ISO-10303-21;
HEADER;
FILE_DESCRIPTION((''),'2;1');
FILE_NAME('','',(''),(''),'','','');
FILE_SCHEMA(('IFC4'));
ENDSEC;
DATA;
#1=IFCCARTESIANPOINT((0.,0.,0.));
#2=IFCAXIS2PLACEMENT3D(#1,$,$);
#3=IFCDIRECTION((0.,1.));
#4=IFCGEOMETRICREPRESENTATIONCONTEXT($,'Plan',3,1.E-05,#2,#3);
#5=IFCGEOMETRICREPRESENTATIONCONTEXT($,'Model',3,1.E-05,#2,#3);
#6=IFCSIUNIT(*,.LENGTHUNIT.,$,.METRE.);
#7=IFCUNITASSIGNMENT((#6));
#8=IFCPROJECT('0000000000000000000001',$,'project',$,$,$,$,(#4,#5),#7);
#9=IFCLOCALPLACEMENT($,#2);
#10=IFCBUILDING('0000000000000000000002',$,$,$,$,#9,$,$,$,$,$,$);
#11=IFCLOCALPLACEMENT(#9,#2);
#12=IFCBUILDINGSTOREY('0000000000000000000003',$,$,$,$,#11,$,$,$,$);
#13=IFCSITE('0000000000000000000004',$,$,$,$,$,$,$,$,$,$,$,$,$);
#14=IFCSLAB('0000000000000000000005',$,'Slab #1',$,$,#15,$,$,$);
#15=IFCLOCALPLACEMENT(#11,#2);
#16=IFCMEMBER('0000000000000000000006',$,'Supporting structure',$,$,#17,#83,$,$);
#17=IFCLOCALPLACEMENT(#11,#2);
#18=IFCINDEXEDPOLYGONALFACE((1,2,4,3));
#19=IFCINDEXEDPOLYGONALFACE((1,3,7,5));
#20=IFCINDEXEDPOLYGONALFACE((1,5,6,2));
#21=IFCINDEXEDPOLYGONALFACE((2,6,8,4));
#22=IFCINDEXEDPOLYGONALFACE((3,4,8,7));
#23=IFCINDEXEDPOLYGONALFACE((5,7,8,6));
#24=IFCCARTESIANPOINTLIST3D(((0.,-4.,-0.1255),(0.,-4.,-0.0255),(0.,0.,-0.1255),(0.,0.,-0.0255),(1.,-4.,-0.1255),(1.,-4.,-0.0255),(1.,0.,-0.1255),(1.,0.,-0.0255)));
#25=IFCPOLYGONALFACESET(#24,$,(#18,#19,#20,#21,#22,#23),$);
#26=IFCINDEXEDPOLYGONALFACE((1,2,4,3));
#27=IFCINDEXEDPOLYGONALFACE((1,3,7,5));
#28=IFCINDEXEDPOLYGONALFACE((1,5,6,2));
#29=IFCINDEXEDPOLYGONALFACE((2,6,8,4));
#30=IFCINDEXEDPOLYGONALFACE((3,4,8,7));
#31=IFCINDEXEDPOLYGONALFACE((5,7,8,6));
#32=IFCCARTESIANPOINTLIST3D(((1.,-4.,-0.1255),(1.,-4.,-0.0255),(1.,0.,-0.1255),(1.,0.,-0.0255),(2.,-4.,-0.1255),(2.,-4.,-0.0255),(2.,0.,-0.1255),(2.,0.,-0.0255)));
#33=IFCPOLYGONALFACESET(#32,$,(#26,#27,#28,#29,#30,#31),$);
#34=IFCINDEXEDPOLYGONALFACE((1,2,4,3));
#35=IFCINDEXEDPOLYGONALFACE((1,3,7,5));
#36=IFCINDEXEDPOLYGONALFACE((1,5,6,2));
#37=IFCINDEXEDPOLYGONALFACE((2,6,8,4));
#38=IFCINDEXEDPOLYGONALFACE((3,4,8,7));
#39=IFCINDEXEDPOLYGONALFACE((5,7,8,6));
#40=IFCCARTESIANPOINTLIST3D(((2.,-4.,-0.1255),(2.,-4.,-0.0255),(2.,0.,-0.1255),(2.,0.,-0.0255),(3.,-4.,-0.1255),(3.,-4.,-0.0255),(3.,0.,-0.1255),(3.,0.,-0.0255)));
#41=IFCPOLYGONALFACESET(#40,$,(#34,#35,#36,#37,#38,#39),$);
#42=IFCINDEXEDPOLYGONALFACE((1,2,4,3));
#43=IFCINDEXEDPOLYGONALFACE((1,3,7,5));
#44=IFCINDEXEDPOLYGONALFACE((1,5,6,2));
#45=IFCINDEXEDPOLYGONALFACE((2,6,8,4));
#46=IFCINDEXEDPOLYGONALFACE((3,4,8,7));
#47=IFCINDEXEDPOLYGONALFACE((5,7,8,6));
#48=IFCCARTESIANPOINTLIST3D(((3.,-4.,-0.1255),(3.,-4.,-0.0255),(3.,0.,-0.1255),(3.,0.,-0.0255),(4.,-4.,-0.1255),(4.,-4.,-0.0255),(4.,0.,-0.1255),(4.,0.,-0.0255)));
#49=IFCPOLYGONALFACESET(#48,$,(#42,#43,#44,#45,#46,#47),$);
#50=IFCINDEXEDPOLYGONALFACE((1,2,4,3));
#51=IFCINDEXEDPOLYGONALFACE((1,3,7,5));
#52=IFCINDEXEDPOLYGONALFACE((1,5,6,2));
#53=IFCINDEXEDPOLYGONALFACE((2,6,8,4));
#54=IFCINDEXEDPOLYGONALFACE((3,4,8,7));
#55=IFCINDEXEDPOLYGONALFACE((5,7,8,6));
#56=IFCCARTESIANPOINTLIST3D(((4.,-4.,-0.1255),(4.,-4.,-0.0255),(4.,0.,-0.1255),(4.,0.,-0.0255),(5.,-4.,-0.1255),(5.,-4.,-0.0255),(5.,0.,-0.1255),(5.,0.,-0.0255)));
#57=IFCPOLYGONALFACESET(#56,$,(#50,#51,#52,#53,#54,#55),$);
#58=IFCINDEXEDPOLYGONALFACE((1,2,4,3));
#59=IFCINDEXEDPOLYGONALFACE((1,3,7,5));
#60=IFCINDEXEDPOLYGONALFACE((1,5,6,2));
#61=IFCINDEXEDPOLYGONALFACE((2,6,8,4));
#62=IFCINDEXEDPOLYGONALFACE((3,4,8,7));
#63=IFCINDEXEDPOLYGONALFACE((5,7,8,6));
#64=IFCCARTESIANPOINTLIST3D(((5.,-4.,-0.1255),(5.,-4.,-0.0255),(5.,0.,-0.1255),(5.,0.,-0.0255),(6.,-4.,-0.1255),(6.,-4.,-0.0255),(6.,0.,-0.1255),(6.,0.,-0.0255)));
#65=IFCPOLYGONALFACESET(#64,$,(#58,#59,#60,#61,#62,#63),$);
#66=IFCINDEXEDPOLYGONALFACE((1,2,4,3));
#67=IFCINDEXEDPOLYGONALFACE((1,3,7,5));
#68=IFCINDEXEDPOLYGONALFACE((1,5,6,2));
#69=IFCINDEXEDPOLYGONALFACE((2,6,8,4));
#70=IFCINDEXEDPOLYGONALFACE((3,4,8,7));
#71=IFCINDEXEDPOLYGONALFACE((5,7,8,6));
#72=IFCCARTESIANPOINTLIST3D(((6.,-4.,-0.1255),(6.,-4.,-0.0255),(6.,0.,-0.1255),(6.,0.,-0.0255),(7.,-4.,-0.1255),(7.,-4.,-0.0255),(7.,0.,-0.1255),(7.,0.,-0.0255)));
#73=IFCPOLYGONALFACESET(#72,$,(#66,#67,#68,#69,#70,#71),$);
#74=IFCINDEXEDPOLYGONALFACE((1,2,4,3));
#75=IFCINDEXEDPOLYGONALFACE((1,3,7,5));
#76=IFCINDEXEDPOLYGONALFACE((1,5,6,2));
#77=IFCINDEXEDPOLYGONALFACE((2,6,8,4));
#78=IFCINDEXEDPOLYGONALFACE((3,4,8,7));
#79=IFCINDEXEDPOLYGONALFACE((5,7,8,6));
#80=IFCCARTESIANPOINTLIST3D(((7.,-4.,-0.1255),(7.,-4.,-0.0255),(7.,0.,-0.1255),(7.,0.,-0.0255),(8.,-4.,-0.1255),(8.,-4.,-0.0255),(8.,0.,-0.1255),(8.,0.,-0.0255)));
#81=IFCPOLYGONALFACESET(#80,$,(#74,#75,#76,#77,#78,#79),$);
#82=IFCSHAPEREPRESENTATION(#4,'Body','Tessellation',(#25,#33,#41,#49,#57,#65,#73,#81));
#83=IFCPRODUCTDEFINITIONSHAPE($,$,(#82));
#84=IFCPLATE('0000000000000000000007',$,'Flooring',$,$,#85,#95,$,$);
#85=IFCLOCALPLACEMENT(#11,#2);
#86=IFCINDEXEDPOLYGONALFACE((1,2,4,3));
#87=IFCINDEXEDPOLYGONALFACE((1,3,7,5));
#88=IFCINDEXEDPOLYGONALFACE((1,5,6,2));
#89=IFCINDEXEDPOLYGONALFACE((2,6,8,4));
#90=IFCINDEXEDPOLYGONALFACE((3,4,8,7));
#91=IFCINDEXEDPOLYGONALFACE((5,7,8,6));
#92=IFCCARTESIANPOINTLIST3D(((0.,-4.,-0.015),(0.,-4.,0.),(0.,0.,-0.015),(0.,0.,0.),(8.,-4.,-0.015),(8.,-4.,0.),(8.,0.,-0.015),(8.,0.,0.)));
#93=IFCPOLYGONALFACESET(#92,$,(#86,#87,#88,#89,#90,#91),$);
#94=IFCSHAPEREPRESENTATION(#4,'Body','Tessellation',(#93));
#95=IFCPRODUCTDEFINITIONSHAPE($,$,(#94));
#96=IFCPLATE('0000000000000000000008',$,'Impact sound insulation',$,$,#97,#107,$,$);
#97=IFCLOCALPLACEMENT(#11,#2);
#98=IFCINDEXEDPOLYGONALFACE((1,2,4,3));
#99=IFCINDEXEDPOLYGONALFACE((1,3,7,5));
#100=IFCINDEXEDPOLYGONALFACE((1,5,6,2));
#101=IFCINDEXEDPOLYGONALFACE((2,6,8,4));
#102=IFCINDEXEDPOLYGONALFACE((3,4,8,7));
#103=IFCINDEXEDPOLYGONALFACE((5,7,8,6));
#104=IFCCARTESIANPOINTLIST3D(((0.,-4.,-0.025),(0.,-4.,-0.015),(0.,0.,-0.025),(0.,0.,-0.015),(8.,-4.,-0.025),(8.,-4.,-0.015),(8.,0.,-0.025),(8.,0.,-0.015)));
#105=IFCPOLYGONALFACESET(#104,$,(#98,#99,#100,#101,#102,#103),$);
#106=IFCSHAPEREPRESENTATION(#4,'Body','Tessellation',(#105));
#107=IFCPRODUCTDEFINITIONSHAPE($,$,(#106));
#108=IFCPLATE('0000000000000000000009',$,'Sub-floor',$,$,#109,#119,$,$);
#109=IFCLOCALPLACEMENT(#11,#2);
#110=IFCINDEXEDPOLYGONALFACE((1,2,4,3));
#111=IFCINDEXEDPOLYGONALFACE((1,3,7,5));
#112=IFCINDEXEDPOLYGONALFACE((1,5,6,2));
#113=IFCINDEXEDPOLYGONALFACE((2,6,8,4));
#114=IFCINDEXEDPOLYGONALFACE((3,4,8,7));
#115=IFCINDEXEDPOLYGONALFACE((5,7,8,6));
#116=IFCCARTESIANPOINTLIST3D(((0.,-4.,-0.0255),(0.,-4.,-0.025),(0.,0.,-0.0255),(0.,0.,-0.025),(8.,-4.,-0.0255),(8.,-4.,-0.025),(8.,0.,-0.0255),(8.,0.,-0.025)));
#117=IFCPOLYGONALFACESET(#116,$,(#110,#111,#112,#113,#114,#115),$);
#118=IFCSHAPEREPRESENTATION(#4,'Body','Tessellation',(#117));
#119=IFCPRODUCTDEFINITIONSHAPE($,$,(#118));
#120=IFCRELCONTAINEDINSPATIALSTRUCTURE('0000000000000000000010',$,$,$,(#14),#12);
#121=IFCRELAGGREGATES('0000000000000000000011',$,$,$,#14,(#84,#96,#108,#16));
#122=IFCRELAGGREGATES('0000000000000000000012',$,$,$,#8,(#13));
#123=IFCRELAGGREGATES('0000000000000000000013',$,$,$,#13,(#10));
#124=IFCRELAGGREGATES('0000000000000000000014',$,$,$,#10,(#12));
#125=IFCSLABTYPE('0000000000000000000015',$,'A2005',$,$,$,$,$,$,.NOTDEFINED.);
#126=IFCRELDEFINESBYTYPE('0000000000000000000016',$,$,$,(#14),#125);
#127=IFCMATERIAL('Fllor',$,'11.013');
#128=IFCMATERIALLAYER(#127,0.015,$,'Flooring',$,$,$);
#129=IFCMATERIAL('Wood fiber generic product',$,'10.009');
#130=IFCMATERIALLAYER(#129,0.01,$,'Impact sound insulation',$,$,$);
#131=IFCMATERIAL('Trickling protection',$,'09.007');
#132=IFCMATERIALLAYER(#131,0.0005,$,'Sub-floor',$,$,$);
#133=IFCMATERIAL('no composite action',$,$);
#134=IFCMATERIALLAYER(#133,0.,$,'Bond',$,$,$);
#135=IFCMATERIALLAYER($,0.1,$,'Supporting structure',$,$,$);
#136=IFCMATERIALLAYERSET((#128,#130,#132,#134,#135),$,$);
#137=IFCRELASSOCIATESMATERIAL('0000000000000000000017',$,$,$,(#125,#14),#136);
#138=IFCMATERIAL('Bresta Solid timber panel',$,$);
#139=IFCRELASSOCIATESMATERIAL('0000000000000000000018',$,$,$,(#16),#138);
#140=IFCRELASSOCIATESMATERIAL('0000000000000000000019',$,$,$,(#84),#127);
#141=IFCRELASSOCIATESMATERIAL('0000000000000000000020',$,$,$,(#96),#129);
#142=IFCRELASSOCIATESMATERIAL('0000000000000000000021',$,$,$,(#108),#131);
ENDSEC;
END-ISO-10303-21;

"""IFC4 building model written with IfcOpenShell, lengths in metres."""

from ifc_helpers import new_model, si_unit, direction, frame, frame_2d, origin, origin_with_axes, place, context, project, spatial, rectangle, extrude, material, layer, layer_set, type_object, element, aggregate, save


model = new_model("IFC4")

# Units and contexts
plan_context = context("Plan", 3, precision=1e-05, world=origin(), true_north=direction((0.0, 1.0)))
model_context = context("Model", 3, precision=1e-05, world=origin(), true_north=direction((0.0, 1.0)))
ifc_project = project(units=[si_unit("LENGTHUNIT", "METRE")], contexts=[plan_context, model_context])

# Site, building, storey
site = spatial("IfcSite", under=ifc_project)
building_placement = place(None, origin())
building = spatial("IfcBuilding", under=site, at=building_placement)
storey_placement = place(building_placement, origin())
storey = spatial("IfcBuildingStorey", under=building, at=storey_placement)

# Slab, member, plates
ifc_material_1 = material(Name="Fllor", Category="11.013")
ifc_layer_1 = layer(ifc_material_1, 0.015, Name="Flooring")
ifc_material_2 = material(Name="Wood fiber generic product", Category="10.009")
ifc_layer_2 = layer(ifc_material_2, 0.01, Name="Impact sound insulation")
ifc_material_3 = material(Name="Trickling protection", Category="09.007")
ifc_layer_3 = layer(ifc_material_3, 0.0005, Name="Sub-floor")
ifc_material_4 = material(Name="no composite action")
ifc_layer_4 = layer(ifc_material_4, 0.0, Name="Bond")
ifc_layer_5 = layer(None, 0.1, Name="Supporting structure")
ifc_layer_set = layer_set([ifc_layer_1, ifc_layer_2, ifc_layer_3, ifc_layer_4, ifc_layer_5])
slab_type = type_object("IfcSlabType", Name="A2005", PredefinedType="NOTDEFINED", material=ifc_layer_set)
slab_placement = place(None, frame((0.0, 0.0, 0.0), z_axis=(0.0, 0.0, -1.0), x_axis=(1.0, 0.0, 0.0)))
slab = element("IfcSlab", 1, at=slab_placement, inside=storey, type_object=slab_type, material=ifc_layer_set, Name="Slab #1")
ifc_material_5 = material(Name="Bresta Solid timber panel")
member_placement = place(slab_placement, origin())
member = element("IfcMember", 2, at=member_placement, material=ifc_material_5, Name="Supporting structure", context=plan_context, shape_type="SweptSolid", body=[
    extrude(rectangle(XDim=1.0, YDim=0.1, at=frame_2d((0.5, 0.05), x_axis=(1.0, 0.0))), frame((0.0, 4.0, 0.0255), z_axis=(0.0, -1.0, 0.0), x_axis=(1.0, 0.0, 0.0)), (0.0, 0.0, 1.0), 4.0),
    extrude(rectangle(XDim=1.0, YDim=0.1, at=frame_2d((0.5, 0.05), x_axis=(1.0, 0.0))), frame((1.0, 4.0, 0.0255), z_axis=(0.0, -1.0, 0.0), x_axis=(1.0, 0.0, 0.0)), (0.0, 0.0, 1.0), 4.0),
    extrude(rectangle(XDim=1.0, YDim=0.1, at=frame_2d((0.5, 0.05), x_axis=(1.0, 0.0))), frame((2.0, 4.0, 0.0255), z_axis=(0.0, -1.0, 0.0), x_axis=(1.0, 0.0, 0.0)), (0.0, 0.0, 1.0), 4.0),
    extrude(rectangle(XDim=1.0, YDim=0.1, at=frame_2d((0.5, 0.05), x_axis=(1.0, 0.0))), frame((3.0, 4.0, 0.0255), z_axis=(0.0, -1.0, 0.0), x_axis=(1.0, 0.0, 0.0)), (0.0, 0.0, 1.0), 4.0),
    extrude(rectangle(XDim=1.0, YDim=0.1, at=frame_2d((0.5, 0.05), x_axis=(1.0, 0.0))), frame((4.0, 4.0, 0.0255), z_axis=(0.0, -1.0, 0.0), x_axis=(1.0, 0.0, 0.0)), (0.0, 0.0, 1.0), 4.0),
    extrude(rectangle(XDim=1.0, YDim=0.1, at=frame_2d((0.5, 0.05), x_axis=(1.0, 0.0))), frame((5.0, 4.0, 0.0255), z_axis=(0.0, -1.0, 0.0), x_axis=(1.0, 0.0, 0.0)), (0.0, 0.0, 1.0), 4.0),
    extrude(rectangle(XDim=1.0, YDim=0.1, at=frame_2d((0.5, 0.05), x_axis=(1.0, 0.0))), frame((6.0, 4.0, 0.0255), z_axis=(0.0, -1.0, 0.0), x_axis=(1.0, 0.0, 0.0)), (0.0, 0.0, 1.0), 4.0),
    extrude(rectangle(XDim=1.0, YDim=0.1, at=frame_2d((0.5, 0.05), x_axis=(1.0, 0.0))), frame((7.0, 4.0, 0.0255), z_axis=(0.0, -1.0, 0.0), x_axis=(1.0, 0.0, 0.0)), (0.0, 0.0, 1.0), 4.0),
])
plate_1_placement = place(slab_placement, origin())
plate_1 = element("IfcPlate", 3, at=plate_1_placement, material=ifc_material_1, Name="Flooring", context=plan_context, shape_type="SweptSolid", body=[
    extrude(rectangle(XDim=8.0, YDim=4.0, at=frame_2d((4.0, 2.0), x_axis=(1.0, 0.0))), origin_with_axes(), (0.0, 0.0, 1.0), 0.015),
])
plate_2_placement = place(slab_placement, origin())
plate_2 = element("IfcPlate", 4, at=plate_2_placement, material=ifc_material_2, Name="Impact sound insulation", context=plan_context, shape_type="SweptSolid", body=[
    extrude(rectangle(XDim=8.0, YDim=4.0, at=frame_2d((4.0, 2.0), x_axis=(1.0, 0.0))), frame((0.0, 0.0, 0.015), z_axis=(0.0, 0.0, 1.0), x_axis=(1.0, 0.0, 0.0)), (0.0, 0.0, 1.0), 0.01),
])
plate_3_placement = place(slab_placement, origin())
plate_3 = element("IfcPlate", 5, at=plate_3_placement, material=ifc_material_3, Name="Sub-floor", context=plan_context, shape_type="SweptSolid", body=[
    extrude(rectangle(XDim=8.0, YDim=4.0, at=frame_2d((4.0, 2.0), x_axis=(1.0, 0.0))), frame((0.0, 0.0, 0.025), z_axis=(0.0, 0.0, 1.0), x_axis=(1.0, 0.0, 0.0)), (0.0, 0.0, 1.0), 0.0005),
])
aggregate(slab, [plate_1, plate_2, plate_3, member])

save(model, "model.ifc")
